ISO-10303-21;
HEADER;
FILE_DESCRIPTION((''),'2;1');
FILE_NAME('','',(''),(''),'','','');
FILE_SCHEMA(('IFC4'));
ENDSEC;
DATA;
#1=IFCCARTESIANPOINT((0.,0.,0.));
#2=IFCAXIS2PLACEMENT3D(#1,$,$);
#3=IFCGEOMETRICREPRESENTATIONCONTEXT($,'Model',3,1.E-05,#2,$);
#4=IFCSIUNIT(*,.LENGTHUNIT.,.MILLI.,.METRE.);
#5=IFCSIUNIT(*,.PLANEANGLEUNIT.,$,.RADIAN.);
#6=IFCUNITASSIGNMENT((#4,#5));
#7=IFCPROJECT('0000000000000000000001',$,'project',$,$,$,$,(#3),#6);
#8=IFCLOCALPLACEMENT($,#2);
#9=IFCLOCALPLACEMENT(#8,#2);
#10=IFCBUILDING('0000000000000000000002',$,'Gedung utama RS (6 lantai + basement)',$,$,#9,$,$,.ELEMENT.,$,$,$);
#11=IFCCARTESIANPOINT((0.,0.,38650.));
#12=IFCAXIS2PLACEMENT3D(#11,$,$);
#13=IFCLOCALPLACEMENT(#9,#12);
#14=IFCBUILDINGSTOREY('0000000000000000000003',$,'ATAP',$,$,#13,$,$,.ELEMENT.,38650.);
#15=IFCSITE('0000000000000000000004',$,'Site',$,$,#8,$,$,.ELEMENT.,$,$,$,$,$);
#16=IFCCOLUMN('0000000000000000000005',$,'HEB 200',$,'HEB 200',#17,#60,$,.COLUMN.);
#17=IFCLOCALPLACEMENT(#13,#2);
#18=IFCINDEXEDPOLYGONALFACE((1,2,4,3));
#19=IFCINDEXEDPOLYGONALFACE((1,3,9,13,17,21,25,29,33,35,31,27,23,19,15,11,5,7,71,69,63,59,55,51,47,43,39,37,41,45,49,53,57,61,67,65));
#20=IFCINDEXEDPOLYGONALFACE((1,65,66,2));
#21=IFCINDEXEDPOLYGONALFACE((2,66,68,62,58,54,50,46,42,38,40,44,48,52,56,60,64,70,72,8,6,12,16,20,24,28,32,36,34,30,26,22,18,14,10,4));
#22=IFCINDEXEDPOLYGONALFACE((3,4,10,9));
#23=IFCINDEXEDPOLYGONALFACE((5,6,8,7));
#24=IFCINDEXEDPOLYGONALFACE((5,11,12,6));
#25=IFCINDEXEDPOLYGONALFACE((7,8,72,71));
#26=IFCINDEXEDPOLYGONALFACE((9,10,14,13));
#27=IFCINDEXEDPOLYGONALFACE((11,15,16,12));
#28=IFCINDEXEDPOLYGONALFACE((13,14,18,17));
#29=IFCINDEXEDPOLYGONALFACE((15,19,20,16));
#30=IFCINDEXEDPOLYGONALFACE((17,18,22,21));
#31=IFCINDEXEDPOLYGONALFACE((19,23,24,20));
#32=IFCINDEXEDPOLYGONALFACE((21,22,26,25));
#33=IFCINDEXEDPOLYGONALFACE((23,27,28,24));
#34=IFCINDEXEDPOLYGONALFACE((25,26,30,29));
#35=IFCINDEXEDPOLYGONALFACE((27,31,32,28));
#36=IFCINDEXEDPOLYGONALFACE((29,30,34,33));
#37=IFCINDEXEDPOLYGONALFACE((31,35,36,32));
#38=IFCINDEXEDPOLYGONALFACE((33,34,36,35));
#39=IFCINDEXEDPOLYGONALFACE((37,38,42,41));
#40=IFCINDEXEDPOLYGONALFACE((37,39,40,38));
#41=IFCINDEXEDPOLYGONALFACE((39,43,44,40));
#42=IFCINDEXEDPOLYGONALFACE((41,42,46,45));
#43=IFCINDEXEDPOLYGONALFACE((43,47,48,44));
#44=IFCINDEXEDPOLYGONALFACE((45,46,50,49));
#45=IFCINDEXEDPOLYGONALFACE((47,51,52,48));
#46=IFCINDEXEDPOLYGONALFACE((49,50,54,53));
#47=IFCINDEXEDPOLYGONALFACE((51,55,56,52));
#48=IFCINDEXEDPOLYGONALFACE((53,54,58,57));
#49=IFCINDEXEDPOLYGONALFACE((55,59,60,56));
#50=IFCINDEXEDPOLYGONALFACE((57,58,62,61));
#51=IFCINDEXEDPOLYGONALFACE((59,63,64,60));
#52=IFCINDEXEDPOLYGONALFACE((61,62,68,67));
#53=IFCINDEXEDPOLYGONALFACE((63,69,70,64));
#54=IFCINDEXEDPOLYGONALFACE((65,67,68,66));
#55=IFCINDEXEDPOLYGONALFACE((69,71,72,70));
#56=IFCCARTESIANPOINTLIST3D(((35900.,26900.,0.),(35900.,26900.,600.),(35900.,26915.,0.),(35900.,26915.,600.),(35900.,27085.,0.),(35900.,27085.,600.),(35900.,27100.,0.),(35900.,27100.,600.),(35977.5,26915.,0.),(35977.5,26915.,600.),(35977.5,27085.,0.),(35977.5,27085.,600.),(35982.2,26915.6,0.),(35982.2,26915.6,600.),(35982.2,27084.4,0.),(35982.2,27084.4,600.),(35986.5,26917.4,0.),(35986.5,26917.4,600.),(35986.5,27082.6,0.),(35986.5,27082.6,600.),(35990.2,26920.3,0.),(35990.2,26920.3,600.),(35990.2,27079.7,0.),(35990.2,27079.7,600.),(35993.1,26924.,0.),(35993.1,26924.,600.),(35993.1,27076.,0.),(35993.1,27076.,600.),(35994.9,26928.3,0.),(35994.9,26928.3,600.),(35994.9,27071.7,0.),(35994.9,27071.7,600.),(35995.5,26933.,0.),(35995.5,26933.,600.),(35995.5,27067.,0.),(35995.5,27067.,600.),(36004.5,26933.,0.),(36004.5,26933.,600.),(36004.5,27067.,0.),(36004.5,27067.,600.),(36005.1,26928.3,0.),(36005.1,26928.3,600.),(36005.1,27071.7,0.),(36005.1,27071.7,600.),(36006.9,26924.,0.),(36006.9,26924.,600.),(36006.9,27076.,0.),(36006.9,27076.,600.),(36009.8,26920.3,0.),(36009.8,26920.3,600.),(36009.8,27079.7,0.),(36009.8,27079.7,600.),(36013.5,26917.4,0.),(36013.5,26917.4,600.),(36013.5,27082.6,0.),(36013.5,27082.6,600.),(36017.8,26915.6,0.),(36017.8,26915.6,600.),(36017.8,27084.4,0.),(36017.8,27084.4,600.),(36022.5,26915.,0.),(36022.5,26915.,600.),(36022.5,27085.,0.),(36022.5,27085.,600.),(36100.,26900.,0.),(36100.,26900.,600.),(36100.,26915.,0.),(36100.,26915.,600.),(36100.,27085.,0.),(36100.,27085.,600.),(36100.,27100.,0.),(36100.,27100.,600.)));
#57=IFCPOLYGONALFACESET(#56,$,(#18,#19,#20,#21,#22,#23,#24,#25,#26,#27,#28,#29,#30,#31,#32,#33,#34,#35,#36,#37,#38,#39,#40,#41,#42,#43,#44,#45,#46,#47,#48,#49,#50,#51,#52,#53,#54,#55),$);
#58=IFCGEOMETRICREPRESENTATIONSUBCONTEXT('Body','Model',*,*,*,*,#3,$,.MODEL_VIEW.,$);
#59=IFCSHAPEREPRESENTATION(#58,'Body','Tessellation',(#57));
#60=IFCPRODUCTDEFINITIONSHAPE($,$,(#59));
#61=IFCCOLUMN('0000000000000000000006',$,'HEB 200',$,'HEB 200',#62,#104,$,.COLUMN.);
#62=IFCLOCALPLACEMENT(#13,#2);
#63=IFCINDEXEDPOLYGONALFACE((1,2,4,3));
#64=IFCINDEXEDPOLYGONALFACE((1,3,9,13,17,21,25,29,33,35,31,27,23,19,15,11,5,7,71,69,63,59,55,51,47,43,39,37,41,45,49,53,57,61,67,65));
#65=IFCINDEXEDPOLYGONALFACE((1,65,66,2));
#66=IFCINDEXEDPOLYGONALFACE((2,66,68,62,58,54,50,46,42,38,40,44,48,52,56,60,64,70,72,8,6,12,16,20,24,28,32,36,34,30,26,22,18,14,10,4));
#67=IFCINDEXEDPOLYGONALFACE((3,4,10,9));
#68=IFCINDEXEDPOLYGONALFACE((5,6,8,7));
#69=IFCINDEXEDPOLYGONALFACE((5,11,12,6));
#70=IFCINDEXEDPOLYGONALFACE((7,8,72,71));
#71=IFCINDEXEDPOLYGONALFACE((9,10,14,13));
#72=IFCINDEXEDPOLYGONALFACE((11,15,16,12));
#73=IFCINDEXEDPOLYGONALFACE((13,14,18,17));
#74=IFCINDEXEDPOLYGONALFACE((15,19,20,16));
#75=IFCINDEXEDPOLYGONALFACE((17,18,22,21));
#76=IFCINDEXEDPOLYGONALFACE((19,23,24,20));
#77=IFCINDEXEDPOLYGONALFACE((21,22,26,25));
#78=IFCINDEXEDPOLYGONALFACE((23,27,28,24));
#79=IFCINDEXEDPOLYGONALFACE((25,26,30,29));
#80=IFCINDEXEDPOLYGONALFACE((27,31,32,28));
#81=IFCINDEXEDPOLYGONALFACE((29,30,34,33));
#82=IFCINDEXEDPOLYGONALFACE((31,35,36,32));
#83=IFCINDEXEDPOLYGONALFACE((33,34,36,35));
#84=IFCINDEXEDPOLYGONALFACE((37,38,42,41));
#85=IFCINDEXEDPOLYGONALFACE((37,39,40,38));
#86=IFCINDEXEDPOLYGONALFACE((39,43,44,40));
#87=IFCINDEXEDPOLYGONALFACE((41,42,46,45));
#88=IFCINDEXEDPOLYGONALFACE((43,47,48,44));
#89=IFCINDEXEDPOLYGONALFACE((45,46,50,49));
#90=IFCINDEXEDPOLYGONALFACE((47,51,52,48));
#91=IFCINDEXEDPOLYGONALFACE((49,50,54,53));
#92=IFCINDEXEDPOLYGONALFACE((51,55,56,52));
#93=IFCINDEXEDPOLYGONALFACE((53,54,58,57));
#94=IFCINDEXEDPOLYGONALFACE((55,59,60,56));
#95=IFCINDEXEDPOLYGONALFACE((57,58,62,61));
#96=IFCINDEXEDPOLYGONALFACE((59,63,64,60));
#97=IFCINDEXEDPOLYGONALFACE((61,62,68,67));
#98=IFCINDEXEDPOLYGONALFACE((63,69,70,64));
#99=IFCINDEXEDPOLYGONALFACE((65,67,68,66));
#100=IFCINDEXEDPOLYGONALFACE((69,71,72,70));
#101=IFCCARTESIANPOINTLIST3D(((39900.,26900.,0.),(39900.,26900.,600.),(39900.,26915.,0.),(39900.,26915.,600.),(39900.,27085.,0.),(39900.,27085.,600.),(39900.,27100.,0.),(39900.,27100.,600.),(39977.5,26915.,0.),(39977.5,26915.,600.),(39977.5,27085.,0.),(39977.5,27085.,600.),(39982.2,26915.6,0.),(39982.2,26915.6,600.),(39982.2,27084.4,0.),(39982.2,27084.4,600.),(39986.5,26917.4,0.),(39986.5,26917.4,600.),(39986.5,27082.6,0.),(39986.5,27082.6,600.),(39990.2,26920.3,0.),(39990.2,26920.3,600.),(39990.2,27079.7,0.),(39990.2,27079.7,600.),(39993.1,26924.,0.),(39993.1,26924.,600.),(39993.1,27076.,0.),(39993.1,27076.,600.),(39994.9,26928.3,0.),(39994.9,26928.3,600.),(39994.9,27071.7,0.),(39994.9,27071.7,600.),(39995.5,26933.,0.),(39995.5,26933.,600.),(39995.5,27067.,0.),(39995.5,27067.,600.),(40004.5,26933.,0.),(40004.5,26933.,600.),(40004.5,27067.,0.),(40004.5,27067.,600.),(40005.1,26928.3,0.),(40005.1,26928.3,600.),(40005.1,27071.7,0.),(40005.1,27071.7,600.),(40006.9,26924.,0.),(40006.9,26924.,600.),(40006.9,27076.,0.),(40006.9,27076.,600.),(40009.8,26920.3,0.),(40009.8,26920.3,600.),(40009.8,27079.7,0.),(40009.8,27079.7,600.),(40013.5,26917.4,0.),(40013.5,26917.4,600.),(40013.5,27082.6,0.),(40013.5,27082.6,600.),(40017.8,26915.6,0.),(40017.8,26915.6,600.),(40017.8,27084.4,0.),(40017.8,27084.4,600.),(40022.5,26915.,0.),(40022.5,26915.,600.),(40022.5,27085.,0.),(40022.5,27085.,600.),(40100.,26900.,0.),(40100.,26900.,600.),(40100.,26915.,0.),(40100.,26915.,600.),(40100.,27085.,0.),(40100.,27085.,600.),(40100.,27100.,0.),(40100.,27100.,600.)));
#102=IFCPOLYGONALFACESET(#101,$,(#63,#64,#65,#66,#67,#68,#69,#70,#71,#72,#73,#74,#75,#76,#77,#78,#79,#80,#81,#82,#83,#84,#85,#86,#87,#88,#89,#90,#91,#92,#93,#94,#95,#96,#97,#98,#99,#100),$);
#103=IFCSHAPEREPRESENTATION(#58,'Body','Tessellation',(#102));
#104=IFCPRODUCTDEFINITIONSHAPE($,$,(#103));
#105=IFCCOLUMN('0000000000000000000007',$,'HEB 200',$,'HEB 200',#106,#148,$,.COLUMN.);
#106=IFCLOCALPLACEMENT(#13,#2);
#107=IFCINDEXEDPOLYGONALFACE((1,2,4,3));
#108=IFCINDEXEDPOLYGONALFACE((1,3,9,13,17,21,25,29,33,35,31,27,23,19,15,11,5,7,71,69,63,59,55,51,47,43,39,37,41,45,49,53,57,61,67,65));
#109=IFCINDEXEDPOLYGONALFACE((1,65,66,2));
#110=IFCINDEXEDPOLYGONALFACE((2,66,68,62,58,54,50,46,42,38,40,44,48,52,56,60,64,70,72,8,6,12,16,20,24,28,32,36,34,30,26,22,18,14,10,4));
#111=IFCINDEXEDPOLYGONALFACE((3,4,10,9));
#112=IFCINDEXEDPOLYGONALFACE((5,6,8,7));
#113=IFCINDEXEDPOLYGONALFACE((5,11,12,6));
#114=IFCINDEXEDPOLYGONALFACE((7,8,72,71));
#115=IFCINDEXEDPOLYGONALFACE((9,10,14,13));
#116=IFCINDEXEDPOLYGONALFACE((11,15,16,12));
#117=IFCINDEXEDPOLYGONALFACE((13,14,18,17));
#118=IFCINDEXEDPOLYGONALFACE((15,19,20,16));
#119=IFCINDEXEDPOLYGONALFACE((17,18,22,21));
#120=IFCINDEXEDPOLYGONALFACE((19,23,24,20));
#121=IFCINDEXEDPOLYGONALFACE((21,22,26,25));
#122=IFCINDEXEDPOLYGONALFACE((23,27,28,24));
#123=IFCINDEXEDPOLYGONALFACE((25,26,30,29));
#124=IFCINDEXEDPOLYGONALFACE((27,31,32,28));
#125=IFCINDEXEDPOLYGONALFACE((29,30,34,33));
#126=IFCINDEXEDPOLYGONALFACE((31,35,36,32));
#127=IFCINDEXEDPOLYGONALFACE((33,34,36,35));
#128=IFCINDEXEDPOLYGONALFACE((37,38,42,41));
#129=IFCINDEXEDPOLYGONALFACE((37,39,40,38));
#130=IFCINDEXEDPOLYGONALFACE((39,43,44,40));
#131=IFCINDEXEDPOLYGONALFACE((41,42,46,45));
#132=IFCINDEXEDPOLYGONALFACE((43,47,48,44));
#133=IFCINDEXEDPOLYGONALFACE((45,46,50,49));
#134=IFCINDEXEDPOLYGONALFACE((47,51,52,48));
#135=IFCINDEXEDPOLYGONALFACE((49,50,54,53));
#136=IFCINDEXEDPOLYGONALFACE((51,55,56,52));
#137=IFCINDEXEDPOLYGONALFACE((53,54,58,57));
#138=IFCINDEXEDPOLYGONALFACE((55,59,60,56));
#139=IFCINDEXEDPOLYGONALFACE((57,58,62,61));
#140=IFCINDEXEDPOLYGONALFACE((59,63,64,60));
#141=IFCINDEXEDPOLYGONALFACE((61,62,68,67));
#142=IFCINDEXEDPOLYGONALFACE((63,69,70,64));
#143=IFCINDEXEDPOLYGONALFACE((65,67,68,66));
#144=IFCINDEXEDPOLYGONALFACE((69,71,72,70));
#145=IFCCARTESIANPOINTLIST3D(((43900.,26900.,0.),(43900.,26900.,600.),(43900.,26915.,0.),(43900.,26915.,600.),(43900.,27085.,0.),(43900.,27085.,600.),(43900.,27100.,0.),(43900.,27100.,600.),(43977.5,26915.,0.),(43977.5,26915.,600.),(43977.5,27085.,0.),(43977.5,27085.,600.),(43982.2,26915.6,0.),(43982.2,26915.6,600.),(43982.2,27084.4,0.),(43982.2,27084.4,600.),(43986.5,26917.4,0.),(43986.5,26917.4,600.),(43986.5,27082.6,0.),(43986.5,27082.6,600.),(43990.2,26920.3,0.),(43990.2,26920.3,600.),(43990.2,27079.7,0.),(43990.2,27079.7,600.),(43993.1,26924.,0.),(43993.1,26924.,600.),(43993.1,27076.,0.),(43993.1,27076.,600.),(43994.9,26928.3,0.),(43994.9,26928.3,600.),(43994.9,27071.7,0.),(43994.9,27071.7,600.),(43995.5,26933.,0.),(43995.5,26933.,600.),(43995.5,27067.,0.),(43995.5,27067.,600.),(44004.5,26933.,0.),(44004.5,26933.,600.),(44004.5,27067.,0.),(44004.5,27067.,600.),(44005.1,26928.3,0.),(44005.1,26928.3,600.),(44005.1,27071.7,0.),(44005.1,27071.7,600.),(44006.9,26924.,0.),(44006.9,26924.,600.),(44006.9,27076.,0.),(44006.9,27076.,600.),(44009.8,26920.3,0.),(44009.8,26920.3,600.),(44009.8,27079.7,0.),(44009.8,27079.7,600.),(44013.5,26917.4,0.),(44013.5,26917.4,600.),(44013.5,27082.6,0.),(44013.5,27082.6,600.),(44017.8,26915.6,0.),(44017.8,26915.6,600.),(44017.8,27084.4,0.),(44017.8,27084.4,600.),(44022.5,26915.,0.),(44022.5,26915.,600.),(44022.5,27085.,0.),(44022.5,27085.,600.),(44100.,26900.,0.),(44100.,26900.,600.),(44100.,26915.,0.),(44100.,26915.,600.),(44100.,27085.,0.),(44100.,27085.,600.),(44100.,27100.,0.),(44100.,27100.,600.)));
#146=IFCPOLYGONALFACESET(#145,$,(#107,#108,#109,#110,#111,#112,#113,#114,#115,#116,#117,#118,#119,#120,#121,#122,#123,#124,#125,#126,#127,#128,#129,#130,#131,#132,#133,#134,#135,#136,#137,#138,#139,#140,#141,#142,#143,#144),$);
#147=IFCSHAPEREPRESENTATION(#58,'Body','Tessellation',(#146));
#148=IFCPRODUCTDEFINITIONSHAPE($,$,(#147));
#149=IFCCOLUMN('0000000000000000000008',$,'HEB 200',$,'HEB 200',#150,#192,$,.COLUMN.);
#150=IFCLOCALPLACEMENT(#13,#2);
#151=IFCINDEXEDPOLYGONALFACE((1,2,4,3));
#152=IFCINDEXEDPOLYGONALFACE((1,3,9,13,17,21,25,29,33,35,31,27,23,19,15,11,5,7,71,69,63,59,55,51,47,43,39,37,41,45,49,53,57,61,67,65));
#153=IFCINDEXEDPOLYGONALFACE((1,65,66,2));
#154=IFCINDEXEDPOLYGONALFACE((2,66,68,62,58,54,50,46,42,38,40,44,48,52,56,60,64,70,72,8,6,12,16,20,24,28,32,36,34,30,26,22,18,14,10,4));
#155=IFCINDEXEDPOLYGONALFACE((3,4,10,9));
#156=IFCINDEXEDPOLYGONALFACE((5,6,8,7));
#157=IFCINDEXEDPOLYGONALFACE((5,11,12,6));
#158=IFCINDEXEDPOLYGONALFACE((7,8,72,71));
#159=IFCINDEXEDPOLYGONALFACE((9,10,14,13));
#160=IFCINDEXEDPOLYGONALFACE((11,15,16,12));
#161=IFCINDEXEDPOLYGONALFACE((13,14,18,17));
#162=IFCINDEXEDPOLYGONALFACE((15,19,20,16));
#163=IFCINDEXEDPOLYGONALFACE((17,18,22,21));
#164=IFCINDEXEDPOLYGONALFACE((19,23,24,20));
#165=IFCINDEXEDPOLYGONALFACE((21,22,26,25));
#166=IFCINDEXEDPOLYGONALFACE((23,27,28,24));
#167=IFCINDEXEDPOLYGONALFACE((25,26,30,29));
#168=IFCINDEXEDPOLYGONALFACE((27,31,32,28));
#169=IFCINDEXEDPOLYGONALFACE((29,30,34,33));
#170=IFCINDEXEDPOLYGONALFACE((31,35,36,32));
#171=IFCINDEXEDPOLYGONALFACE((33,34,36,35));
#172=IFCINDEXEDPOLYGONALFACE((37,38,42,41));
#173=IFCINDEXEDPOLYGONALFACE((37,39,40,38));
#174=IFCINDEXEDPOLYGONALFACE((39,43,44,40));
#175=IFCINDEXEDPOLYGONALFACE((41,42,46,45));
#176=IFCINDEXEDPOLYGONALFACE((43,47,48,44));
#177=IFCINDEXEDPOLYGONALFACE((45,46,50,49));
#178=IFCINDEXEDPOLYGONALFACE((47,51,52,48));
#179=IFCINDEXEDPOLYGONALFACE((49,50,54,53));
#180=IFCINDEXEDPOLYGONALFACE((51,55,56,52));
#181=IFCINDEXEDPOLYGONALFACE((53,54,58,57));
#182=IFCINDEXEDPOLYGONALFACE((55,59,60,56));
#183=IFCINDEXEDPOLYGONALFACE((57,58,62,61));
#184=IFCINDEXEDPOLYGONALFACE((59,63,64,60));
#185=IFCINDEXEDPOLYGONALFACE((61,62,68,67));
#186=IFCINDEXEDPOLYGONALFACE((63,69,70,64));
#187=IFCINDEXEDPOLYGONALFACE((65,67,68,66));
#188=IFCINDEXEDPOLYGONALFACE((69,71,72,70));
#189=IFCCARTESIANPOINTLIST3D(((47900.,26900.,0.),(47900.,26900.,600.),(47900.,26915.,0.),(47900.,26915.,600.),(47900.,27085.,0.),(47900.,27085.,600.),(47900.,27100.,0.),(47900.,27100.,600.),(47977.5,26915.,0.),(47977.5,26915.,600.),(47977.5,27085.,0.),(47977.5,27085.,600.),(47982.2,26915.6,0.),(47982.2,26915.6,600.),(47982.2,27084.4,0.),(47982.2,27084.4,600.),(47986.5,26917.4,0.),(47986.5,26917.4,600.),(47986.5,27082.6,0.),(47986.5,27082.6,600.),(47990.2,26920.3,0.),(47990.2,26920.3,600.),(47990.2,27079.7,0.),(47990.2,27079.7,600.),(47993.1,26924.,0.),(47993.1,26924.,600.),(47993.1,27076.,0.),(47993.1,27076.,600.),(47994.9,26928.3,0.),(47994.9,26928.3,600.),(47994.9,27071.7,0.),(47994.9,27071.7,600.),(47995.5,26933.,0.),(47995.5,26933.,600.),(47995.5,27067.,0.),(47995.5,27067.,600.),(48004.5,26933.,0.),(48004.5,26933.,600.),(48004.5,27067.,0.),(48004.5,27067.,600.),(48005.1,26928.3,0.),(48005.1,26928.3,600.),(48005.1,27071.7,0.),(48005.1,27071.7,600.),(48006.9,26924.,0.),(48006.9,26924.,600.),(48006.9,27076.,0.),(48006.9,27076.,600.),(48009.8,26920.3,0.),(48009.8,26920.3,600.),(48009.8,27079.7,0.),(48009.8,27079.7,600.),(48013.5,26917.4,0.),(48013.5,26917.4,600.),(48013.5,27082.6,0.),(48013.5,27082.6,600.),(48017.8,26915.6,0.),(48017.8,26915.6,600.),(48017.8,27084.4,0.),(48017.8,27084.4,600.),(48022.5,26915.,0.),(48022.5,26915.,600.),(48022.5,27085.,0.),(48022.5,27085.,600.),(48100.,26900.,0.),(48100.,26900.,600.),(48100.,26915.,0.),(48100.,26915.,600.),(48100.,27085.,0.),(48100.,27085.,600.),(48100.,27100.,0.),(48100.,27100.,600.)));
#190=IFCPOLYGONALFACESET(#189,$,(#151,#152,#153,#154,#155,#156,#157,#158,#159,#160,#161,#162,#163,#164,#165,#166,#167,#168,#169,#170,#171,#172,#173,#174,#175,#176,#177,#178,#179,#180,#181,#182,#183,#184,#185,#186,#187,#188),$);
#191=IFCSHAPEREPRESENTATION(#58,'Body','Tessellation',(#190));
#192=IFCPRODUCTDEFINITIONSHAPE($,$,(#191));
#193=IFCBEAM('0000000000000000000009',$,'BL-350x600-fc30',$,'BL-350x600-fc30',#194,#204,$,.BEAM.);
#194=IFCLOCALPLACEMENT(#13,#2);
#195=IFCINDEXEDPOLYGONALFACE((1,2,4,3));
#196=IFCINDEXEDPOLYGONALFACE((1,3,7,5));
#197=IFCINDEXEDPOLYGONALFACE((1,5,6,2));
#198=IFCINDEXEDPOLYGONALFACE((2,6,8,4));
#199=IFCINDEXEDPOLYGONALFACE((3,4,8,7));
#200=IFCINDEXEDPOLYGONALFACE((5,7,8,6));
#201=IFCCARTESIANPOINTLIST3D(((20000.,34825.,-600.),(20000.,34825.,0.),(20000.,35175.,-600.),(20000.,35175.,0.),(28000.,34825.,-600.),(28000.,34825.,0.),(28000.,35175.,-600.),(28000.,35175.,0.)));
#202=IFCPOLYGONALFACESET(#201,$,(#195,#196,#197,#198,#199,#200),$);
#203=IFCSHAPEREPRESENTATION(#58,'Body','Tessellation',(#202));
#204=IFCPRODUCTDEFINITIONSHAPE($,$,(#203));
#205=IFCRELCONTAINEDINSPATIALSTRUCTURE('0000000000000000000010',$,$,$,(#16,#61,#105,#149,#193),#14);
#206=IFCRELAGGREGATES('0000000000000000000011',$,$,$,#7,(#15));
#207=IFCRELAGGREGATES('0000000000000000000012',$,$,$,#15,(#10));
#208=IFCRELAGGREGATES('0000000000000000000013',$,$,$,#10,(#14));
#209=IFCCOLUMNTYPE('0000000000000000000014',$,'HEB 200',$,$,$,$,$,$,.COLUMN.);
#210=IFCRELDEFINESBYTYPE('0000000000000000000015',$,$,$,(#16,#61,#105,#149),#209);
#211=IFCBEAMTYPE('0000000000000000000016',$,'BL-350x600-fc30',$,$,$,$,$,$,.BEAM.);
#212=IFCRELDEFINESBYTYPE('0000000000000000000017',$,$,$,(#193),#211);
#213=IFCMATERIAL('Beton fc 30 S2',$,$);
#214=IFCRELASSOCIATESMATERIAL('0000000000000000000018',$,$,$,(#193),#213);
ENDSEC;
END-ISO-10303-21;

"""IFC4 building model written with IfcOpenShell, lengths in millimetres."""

from ifc_helpers import new_model, si_unit, frame, origin, origin_2d, place, context, subcontext, project, spatial, rectangle, i_section, extrude, material, material_profile, profile_set, profile_usage, type_object, element, save


model = new_model("IFC4")

# Units and contexts
model_context = context("Model", 3, precision=1e-05, world=origin())
body_context = subcontext(model_context, "Body", "Model", "MODEL_VIEW")
ifc_project = project(units=[si_unit("LENGTHUNIT", "METRE", prefix="MILLI"), si_unit("PLANEANGLEUNIT", "RADIAN")], contexts=[model_context])

# Site, building, storey
site_placement = place(None, origin())
site = spatial("IfcSite", under=ifc_project, at=site_placement, Name="Site", CompositionType="ELEMENT")
building_placement = place(site_placement, origin())
building = spatial("IfcBuilding", under=site, at=building_placement, Name="Gedung utama RS (6 lantai + basement)", CompositionType="ELEMENT")
storey_placement = place(building_placement, frame((0.0, 0.0, 38650.0)))
storey = spatial("IfcBuildingStorey", under=building, at=storey_placement, Name="ATAP", CompositionType="ELEMENT", Elevation=38650.0)

# Columns
ifc_material_profile_1 = material_profile(None, i_section(OverallWidth=200.0, OverallDepth=200.0, WebThickness=9.0, FlangeThickness=15.0, FilletRadius=18.0, at=origin_2d()), Name="HEB 200")
ifc_profile_set_1 = profile_set([ifc_material_profile_1], Name="HEB 200")
ifc_profile_usage_1 = profile_usage(ifc_profile_set_1, cardinal=5)
column_type = type_object("IfcColumnType", Name="HEB 200", PredefinedType="COLUMN")
for number, where, z_axis, x_axis, name in (
    (1, (36000.0, 27000.0, 0.0), (0.0, 0.0, 1.0), (1.0, 0.0, 0.0), "HEB 200"),
    (2, (40000.0, 27000.0, 0.0), (0.0, 0.0, 1.0), (1.0, 0.0, 0.0), "HEB 200"),
    (3, (44000.0, 27000.0, 0.0), (0.0, 0.0, 1.0), (1.0, 0.0, 0.0), "HEB 200"),
    (4, (48000.0, 27000.0, 0.0), (0.0, 0.0, 1.0), (1.0, 0.0, 0.0), "HEB 200"),
):
    element("IfcColumn", number, at=place(storey_placement, frame(where, z_axis=z_axis, x_axis=x_axis)), inside=storey, type_object=column_type, material=ifc_profile_usage_1, Name=name, ObjectType="HEB 200", PredefinedType="COLUMN", context=body_context, shape_type="SweptSolid", body=[
        extrude(i_section(OverallWidth=200.0, OverallDepth=200.0, WebThickness=9.0, FlangeThickness=15.0, FilletRadius=18.0, at=origin_2d()), origin(), (0.0, 0.0, 1.0), 600.0),
    ])

# Beam
ifc_material_1 = material(Name="Beton fc 30 S2")
ifc_material_profile_2 = material_profile(ifc_material_1, rectangle(XDim=350.0, YDim=600.0, at=origin_2d()), Name="BL-350x600-fc30")
ifc_profile_set_2 = profile_set([ifc_material_profile_2], Name="BL-350x600-fc30")
ifc_profile_usage_2 = profile_usage(ifc_profile_set_2, cardinal=8)
beam_type = type_object("IfcBeamType", Name="BL-350x600-fc30", PredefinedType="BEAM")
beam_1_placement = place(storey_placement, frame((20000.0, 35000.0, -300.0)))
element("IfcBeam", 5, at=beam_1_placement, inside=storey, type_object=beam_type, material=ifc_profile_usage_2, Name="BL-350x600-fc30", ObjectType="BL-350x600-fc30", PredefinedType="BEAM", context=body_context, shape_type="SweptSolid", body=[
    extrude(rectangle(XDim=350.0, YDim=600.0, at=origin_2d()), frame((0.0, 0.0, 0.0), z_axis=(1.0, 0.0, 0.0), x_axis=(0.0, 1.0, 0.0)), (0.0, 0.0, 1.0), 8000.0),
])

save(model, "model.ifc")
